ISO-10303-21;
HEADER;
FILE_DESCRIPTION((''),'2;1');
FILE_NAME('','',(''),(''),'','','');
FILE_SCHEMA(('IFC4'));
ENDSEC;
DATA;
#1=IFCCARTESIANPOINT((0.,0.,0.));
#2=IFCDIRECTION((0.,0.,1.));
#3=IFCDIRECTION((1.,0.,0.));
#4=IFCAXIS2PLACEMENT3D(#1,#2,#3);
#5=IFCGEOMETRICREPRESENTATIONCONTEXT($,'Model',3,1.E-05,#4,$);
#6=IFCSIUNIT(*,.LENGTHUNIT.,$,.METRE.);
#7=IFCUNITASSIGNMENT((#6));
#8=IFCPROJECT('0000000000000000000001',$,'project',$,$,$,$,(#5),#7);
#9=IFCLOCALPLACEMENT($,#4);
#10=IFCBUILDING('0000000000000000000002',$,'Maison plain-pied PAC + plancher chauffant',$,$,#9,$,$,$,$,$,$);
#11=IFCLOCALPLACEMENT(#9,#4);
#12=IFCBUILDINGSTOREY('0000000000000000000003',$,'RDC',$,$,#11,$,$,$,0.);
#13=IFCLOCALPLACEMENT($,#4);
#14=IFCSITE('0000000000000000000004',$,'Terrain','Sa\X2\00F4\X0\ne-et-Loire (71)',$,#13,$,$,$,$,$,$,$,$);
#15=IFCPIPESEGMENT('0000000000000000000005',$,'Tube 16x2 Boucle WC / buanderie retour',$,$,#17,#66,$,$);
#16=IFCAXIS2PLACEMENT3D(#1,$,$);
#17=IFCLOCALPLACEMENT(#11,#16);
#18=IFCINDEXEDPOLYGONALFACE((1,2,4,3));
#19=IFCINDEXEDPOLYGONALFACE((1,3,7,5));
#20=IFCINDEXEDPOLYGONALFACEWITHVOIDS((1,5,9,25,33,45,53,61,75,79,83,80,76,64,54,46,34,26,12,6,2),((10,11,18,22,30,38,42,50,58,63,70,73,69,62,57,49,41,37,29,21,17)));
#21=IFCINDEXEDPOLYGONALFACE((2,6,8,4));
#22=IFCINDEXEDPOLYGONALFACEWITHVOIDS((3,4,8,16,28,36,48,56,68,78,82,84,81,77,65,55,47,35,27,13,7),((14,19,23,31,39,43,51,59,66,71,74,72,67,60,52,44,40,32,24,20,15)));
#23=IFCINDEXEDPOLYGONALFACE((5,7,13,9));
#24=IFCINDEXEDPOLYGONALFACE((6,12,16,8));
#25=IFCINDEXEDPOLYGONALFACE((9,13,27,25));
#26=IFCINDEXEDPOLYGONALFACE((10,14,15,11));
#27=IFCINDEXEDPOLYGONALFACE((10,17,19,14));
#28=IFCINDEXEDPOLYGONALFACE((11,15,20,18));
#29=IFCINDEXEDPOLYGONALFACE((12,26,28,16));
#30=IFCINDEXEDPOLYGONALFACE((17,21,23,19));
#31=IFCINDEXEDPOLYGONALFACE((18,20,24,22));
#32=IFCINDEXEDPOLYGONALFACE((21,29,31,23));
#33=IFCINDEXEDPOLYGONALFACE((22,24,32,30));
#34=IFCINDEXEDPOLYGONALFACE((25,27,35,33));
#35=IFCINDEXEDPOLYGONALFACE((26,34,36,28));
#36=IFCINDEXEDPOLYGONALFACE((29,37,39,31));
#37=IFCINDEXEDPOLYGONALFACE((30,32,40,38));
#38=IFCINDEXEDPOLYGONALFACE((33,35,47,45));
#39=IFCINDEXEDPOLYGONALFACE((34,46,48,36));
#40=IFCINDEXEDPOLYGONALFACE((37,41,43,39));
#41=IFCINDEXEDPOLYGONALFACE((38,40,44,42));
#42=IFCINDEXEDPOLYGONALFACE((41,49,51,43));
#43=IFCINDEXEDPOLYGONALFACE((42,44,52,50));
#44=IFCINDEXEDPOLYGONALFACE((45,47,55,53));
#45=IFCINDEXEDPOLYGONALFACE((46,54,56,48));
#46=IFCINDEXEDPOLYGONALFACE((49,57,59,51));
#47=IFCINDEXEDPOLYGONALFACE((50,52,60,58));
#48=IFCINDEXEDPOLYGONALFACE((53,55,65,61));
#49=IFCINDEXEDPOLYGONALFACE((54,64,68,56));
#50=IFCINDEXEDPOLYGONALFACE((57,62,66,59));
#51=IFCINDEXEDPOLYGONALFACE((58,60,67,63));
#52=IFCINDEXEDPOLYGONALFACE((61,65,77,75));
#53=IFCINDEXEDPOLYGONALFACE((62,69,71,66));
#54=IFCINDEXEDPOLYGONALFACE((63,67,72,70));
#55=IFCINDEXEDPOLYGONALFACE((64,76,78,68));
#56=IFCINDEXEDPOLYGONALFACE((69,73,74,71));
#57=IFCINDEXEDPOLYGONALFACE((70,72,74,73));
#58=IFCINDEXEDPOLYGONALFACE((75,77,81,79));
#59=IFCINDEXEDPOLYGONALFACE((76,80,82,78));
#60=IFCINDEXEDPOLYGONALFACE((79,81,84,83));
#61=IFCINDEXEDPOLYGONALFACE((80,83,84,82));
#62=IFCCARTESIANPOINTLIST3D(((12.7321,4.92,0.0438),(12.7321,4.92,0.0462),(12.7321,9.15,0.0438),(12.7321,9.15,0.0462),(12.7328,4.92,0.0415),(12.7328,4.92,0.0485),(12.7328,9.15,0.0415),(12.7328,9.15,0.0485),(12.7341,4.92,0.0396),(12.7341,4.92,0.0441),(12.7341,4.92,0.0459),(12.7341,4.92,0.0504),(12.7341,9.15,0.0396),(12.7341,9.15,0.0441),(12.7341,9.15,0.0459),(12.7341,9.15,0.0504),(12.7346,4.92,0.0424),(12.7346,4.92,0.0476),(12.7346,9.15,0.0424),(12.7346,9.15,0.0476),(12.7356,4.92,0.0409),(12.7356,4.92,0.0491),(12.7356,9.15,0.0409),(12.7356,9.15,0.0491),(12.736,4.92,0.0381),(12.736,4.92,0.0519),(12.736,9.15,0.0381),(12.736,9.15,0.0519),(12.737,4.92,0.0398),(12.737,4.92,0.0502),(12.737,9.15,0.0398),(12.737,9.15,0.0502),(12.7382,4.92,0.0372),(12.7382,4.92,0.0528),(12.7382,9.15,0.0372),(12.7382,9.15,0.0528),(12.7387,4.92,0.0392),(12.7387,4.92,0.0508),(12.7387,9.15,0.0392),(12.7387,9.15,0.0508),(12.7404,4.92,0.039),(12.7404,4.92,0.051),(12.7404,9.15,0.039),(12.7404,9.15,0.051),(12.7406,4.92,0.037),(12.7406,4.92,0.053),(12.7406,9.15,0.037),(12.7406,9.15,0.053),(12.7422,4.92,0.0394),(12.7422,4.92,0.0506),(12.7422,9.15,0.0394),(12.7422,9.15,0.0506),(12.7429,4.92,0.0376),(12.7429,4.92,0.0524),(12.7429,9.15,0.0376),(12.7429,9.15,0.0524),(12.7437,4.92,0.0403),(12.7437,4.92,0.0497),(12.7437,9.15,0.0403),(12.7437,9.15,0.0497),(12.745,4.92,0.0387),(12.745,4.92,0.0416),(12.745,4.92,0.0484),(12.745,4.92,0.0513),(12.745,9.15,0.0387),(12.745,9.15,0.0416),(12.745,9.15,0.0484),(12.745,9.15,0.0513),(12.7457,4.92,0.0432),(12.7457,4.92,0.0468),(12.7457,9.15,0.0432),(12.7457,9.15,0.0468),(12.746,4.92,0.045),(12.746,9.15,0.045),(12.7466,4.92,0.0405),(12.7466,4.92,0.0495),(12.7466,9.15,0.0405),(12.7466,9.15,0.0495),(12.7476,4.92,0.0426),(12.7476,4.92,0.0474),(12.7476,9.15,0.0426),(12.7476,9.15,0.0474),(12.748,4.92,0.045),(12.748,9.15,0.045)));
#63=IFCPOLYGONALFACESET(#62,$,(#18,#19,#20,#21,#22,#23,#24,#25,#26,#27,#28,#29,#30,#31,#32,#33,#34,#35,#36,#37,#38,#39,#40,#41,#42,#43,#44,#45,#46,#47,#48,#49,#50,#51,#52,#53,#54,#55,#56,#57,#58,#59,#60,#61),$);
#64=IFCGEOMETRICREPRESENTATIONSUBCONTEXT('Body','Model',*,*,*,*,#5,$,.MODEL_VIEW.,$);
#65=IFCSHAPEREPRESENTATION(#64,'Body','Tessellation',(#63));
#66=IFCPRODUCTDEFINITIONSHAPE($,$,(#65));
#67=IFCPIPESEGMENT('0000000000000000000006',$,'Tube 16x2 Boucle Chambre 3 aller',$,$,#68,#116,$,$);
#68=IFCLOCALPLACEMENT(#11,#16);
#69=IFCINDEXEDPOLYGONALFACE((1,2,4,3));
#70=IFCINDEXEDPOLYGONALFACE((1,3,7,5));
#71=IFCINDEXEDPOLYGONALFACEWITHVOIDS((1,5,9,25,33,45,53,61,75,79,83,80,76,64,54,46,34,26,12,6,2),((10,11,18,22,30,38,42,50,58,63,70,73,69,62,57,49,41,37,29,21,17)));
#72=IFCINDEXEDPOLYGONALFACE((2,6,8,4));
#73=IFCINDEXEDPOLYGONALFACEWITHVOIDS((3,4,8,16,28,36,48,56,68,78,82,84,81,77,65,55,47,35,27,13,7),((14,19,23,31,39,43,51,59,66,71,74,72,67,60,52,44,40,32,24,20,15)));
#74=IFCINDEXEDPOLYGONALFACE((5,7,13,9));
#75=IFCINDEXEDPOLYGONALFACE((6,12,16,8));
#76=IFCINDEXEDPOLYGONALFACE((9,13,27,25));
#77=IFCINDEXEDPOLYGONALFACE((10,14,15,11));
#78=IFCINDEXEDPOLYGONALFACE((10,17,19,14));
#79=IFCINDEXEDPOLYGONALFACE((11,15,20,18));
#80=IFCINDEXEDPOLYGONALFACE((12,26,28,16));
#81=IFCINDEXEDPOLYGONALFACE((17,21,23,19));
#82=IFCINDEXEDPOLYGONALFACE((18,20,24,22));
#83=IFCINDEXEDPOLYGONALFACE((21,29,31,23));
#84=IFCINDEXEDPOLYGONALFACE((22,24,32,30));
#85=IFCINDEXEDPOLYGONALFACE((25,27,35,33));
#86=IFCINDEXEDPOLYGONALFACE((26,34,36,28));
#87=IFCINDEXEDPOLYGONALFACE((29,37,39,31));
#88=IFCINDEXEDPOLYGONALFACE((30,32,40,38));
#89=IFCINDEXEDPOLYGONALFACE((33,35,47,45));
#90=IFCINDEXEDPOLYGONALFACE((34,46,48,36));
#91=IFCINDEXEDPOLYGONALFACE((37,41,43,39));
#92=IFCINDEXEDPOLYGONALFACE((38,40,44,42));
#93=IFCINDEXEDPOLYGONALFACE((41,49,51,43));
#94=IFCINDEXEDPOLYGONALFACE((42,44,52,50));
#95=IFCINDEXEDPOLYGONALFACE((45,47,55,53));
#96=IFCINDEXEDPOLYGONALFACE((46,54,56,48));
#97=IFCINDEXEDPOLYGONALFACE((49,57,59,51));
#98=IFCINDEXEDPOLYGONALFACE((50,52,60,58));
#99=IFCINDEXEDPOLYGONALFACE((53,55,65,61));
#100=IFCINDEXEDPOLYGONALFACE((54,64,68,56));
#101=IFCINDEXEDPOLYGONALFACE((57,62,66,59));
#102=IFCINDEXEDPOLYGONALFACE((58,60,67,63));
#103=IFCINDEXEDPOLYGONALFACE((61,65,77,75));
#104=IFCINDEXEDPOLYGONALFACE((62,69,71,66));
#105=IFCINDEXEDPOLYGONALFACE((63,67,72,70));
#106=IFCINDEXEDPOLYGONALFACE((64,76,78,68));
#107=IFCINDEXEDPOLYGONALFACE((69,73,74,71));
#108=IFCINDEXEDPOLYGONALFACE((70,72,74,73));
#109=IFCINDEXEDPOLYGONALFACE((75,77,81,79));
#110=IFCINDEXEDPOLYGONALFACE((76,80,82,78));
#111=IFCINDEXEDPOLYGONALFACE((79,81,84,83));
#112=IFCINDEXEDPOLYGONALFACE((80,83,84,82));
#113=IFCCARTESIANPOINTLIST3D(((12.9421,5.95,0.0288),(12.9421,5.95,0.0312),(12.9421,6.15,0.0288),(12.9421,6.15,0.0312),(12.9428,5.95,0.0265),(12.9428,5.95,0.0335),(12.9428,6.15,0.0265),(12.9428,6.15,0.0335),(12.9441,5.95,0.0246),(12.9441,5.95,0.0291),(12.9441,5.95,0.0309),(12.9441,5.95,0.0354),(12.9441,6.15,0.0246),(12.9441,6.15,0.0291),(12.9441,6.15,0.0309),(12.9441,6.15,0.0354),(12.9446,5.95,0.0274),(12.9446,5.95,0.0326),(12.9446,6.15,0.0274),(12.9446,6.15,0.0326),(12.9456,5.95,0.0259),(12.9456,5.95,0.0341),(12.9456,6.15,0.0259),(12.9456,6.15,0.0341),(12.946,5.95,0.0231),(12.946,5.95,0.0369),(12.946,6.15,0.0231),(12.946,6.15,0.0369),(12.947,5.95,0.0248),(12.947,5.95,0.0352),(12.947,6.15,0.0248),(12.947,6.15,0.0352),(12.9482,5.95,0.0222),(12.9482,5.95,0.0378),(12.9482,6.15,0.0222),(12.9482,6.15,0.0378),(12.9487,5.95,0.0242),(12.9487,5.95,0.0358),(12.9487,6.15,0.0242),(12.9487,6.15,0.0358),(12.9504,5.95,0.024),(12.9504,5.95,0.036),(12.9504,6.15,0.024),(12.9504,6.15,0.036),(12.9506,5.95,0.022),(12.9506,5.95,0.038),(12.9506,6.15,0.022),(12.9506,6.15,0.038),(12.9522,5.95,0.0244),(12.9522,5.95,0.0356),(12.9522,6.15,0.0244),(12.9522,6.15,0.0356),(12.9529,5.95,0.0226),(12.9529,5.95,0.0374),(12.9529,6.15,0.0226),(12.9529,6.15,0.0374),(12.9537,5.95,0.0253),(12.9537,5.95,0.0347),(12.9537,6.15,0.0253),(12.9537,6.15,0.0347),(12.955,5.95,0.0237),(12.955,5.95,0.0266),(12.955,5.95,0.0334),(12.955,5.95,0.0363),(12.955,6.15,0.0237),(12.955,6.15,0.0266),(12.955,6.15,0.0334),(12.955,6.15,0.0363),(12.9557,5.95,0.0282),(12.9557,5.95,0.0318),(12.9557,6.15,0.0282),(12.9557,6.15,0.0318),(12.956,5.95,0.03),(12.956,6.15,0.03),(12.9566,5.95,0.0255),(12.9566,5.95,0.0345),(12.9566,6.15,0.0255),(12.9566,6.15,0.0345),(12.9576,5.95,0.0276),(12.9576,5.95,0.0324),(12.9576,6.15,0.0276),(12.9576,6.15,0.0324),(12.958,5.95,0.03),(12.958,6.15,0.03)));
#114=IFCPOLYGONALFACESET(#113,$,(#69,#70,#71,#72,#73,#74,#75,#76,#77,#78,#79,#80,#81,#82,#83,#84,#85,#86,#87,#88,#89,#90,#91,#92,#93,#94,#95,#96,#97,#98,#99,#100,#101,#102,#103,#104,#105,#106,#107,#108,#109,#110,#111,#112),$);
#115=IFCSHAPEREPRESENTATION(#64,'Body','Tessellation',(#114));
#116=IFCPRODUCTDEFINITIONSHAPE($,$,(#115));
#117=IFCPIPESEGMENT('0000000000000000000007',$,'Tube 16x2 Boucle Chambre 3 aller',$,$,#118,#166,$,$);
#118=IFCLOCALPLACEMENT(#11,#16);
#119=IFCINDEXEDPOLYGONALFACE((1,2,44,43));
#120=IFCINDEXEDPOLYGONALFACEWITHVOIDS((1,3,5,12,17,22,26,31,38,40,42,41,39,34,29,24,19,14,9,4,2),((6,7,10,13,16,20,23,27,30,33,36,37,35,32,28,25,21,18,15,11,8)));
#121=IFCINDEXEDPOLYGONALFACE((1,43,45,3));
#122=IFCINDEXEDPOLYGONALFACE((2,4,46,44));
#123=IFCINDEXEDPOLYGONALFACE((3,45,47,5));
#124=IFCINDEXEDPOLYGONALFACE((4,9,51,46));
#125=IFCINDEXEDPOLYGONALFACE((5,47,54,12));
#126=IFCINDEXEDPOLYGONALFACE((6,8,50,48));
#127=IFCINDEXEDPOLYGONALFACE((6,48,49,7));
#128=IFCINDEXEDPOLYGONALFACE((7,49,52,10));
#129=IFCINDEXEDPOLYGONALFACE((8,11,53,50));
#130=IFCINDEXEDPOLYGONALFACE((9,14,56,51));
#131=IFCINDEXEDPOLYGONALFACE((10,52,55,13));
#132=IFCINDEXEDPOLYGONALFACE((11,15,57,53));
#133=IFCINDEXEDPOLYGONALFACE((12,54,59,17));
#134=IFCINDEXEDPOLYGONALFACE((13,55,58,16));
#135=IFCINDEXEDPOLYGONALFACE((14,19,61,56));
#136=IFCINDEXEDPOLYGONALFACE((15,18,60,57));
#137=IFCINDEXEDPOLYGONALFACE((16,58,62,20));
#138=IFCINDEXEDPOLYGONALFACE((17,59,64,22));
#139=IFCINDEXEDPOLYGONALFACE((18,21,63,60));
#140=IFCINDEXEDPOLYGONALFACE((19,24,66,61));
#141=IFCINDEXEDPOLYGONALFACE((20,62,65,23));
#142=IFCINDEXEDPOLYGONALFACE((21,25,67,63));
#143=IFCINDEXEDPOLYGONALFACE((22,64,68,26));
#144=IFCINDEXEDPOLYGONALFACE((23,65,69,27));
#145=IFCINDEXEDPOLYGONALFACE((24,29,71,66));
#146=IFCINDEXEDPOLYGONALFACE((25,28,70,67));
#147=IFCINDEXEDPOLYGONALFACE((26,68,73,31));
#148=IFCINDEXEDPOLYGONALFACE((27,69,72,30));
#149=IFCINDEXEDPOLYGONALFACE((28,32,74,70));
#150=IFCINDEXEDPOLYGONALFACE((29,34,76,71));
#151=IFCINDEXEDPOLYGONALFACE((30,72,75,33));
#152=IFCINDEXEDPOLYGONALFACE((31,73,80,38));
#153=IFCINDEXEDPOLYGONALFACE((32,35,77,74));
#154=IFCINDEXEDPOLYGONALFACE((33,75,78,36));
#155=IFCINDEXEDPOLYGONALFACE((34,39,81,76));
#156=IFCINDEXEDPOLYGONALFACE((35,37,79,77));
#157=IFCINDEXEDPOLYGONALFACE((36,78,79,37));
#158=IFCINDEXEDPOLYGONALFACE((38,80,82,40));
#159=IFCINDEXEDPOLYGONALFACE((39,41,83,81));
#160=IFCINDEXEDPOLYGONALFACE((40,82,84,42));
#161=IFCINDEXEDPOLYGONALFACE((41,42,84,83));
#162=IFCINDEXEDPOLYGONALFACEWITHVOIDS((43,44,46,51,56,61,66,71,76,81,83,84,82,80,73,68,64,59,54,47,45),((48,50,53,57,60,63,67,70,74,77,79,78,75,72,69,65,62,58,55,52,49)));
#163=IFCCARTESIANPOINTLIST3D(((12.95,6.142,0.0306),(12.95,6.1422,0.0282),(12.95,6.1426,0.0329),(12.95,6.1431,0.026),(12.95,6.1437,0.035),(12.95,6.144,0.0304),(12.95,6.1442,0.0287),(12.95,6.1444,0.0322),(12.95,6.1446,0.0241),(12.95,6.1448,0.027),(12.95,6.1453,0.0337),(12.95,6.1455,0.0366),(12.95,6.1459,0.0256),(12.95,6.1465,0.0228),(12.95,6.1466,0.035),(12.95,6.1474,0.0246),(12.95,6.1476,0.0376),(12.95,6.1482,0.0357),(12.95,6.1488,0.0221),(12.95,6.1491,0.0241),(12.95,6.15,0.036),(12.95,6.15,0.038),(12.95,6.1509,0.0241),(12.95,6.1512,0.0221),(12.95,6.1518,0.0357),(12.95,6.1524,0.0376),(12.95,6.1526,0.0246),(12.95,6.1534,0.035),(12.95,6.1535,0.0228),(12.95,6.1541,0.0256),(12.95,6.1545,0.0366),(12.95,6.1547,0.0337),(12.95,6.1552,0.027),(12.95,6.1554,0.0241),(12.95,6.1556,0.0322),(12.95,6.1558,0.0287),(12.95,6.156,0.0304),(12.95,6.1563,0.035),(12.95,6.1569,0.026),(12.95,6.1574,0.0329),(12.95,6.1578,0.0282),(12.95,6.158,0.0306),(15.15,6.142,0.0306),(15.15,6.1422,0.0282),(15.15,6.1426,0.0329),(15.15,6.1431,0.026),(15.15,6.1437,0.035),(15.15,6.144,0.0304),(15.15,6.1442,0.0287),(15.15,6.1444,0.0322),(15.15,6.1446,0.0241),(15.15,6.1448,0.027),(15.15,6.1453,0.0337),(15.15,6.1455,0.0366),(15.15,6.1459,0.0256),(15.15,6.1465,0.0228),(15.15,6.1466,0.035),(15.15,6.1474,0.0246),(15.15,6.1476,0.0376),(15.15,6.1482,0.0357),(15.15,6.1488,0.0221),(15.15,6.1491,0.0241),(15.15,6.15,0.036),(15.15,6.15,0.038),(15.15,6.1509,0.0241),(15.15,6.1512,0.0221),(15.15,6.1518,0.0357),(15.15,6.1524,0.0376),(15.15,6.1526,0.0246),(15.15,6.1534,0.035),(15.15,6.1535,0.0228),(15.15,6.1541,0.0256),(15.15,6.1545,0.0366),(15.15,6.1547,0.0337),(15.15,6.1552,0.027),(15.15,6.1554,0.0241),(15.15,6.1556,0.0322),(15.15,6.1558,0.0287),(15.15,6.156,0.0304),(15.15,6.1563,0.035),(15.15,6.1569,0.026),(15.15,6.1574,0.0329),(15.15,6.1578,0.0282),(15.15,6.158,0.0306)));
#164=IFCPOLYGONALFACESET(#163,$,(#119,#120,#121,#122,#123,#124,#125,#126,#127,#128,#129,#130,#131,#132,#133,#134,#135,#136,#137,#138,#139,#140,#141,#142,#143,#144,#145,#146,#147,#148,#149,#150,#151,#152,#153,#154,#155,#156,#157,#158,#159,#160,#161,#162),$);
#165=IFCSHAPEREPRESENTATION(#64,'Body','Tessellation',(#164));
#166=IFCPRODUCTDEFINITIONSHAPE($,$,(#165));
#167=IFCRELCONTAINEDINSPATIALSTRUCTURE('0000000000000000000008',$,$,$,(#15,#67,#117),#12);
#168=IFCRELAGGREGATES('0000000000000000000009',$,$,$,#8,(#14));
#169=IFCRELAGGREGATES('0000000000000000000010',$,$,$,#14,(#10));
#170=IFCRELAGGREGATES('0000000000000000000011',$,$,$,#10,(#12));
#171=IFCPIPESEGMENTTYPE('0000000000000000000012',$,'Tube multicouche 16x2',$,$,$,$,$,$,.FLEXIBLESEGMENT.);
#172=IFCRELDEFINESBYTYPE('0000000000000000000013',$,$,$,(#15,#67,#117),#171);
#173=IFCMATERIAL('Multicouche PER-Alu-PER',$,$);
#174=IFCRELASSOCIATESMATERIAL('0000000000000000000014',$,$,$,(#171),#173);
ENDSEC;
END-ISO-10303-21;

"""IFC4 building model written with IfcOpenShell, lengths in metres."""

from ifc_helpers import new_model, si_unit, frame, origin_with_axes, place, context, subcontext, project, spatial, hollow_circle, extrude, material, type_object, element, save


model = new_model("IFC4")

# Units and contexts
model_context = context("Model", 3, precision=1e-05, world=origin_with_axes())
body_context = subcontext(model_context, "Body", "Model", "MODEL_VIEW")
ifc_project = project(units=[si_unit("LENGTHUNIT", "METRE")], contexts=[model_context])

# Site, building, storey
site_placement = place(None, origin_with_axes())
site = spatial("IfcSite", under=ifc_project, at=site_placement, Name="Terrain", Description="Saône-et-Loire (71)")
building_placement = place(None, origin_with_axes())
building = spatial("IfcBuilding", under=site, at=building_placement, Name="Maison plain-pied PAC + plancher chauffant")
storey_placement = place(building_placement, origin_with_axes())
storey = spatial("IfcBuildingStorey", under=building, at=storey_placement, Name="RDC", Elevation=0.0)

# Pipe segments
ifc_material_1 = material(Name="Multicouche PER-Alu-PER")
pipe_segment_type_1 = type_object("IfcPipeSegmentType", Name="Tube multicouche 16x2", PredefinedType="FLEXIBLESEGMENT", material=ifc_material_1)
pipe_segment_1_placement = place(storey_placement, frame((12.74, 9.15, 0.045), z_axis=(0.0, -1.0, 0.0), x_axis=(1.0, 0.0, 0.0)))
element("IfcPipeSegment", 1, at=pipe_segment_1_placement, inside=storey, type_object=pipe_segment_type_1, Name="Tube 16x2 Boucle WC / buanderie retour", context=body_context, shape_type="SweptSolid", body=[
    extrude(hollow_circle(Radius=0.008, WallThickness=0.002), origin_with_axes(), (0.0, 0.0, 1.0), 4.23),
])
pipe_segment_2_placement = place(storey_placement, frame((12.95, 5.95, 0.03), z_axis=(0.0, 1.0, 0.0), x_axis=(1.0, 0.0, 0.0)))
element("IfcPipeSegment", 2, at=pipe_segment_2_placement, inside=storey, type_object=pipe_segment_type_1, Name="Tube 16x2 Boucle Chambre 3 aller", context=body_context, shape_type="SweptSolid", body=[
    extrude(hollow_circle(Radius=0.008, WallThickness=0.002), origin_with_axes(), (0.0, 0.0, 1.0), 0.2),
])
pipe_segment_3_placement = place(storey_placement, frame((12.95, 6.15, 0.03), z_axis=(1.0, 0.0, 0.0), x_axis=(0.0, 0.0, 1.0)))
element("IfcPipeSegment", 3, at=pipe_segment_3_placement, inside=storey, type_object=pipe_segment_type_1, Name="Tube 16x2 Boucle Chambre 3 aller", context=body_context, shape_type="SweptSolid", body=[
    extrude(hollow_circle(Radius=0.008, WallThickness=0.002), origin_with_axes(), (0.0, 0.0, 1.0), 2.2),
])

save(model, "model.ifc")
